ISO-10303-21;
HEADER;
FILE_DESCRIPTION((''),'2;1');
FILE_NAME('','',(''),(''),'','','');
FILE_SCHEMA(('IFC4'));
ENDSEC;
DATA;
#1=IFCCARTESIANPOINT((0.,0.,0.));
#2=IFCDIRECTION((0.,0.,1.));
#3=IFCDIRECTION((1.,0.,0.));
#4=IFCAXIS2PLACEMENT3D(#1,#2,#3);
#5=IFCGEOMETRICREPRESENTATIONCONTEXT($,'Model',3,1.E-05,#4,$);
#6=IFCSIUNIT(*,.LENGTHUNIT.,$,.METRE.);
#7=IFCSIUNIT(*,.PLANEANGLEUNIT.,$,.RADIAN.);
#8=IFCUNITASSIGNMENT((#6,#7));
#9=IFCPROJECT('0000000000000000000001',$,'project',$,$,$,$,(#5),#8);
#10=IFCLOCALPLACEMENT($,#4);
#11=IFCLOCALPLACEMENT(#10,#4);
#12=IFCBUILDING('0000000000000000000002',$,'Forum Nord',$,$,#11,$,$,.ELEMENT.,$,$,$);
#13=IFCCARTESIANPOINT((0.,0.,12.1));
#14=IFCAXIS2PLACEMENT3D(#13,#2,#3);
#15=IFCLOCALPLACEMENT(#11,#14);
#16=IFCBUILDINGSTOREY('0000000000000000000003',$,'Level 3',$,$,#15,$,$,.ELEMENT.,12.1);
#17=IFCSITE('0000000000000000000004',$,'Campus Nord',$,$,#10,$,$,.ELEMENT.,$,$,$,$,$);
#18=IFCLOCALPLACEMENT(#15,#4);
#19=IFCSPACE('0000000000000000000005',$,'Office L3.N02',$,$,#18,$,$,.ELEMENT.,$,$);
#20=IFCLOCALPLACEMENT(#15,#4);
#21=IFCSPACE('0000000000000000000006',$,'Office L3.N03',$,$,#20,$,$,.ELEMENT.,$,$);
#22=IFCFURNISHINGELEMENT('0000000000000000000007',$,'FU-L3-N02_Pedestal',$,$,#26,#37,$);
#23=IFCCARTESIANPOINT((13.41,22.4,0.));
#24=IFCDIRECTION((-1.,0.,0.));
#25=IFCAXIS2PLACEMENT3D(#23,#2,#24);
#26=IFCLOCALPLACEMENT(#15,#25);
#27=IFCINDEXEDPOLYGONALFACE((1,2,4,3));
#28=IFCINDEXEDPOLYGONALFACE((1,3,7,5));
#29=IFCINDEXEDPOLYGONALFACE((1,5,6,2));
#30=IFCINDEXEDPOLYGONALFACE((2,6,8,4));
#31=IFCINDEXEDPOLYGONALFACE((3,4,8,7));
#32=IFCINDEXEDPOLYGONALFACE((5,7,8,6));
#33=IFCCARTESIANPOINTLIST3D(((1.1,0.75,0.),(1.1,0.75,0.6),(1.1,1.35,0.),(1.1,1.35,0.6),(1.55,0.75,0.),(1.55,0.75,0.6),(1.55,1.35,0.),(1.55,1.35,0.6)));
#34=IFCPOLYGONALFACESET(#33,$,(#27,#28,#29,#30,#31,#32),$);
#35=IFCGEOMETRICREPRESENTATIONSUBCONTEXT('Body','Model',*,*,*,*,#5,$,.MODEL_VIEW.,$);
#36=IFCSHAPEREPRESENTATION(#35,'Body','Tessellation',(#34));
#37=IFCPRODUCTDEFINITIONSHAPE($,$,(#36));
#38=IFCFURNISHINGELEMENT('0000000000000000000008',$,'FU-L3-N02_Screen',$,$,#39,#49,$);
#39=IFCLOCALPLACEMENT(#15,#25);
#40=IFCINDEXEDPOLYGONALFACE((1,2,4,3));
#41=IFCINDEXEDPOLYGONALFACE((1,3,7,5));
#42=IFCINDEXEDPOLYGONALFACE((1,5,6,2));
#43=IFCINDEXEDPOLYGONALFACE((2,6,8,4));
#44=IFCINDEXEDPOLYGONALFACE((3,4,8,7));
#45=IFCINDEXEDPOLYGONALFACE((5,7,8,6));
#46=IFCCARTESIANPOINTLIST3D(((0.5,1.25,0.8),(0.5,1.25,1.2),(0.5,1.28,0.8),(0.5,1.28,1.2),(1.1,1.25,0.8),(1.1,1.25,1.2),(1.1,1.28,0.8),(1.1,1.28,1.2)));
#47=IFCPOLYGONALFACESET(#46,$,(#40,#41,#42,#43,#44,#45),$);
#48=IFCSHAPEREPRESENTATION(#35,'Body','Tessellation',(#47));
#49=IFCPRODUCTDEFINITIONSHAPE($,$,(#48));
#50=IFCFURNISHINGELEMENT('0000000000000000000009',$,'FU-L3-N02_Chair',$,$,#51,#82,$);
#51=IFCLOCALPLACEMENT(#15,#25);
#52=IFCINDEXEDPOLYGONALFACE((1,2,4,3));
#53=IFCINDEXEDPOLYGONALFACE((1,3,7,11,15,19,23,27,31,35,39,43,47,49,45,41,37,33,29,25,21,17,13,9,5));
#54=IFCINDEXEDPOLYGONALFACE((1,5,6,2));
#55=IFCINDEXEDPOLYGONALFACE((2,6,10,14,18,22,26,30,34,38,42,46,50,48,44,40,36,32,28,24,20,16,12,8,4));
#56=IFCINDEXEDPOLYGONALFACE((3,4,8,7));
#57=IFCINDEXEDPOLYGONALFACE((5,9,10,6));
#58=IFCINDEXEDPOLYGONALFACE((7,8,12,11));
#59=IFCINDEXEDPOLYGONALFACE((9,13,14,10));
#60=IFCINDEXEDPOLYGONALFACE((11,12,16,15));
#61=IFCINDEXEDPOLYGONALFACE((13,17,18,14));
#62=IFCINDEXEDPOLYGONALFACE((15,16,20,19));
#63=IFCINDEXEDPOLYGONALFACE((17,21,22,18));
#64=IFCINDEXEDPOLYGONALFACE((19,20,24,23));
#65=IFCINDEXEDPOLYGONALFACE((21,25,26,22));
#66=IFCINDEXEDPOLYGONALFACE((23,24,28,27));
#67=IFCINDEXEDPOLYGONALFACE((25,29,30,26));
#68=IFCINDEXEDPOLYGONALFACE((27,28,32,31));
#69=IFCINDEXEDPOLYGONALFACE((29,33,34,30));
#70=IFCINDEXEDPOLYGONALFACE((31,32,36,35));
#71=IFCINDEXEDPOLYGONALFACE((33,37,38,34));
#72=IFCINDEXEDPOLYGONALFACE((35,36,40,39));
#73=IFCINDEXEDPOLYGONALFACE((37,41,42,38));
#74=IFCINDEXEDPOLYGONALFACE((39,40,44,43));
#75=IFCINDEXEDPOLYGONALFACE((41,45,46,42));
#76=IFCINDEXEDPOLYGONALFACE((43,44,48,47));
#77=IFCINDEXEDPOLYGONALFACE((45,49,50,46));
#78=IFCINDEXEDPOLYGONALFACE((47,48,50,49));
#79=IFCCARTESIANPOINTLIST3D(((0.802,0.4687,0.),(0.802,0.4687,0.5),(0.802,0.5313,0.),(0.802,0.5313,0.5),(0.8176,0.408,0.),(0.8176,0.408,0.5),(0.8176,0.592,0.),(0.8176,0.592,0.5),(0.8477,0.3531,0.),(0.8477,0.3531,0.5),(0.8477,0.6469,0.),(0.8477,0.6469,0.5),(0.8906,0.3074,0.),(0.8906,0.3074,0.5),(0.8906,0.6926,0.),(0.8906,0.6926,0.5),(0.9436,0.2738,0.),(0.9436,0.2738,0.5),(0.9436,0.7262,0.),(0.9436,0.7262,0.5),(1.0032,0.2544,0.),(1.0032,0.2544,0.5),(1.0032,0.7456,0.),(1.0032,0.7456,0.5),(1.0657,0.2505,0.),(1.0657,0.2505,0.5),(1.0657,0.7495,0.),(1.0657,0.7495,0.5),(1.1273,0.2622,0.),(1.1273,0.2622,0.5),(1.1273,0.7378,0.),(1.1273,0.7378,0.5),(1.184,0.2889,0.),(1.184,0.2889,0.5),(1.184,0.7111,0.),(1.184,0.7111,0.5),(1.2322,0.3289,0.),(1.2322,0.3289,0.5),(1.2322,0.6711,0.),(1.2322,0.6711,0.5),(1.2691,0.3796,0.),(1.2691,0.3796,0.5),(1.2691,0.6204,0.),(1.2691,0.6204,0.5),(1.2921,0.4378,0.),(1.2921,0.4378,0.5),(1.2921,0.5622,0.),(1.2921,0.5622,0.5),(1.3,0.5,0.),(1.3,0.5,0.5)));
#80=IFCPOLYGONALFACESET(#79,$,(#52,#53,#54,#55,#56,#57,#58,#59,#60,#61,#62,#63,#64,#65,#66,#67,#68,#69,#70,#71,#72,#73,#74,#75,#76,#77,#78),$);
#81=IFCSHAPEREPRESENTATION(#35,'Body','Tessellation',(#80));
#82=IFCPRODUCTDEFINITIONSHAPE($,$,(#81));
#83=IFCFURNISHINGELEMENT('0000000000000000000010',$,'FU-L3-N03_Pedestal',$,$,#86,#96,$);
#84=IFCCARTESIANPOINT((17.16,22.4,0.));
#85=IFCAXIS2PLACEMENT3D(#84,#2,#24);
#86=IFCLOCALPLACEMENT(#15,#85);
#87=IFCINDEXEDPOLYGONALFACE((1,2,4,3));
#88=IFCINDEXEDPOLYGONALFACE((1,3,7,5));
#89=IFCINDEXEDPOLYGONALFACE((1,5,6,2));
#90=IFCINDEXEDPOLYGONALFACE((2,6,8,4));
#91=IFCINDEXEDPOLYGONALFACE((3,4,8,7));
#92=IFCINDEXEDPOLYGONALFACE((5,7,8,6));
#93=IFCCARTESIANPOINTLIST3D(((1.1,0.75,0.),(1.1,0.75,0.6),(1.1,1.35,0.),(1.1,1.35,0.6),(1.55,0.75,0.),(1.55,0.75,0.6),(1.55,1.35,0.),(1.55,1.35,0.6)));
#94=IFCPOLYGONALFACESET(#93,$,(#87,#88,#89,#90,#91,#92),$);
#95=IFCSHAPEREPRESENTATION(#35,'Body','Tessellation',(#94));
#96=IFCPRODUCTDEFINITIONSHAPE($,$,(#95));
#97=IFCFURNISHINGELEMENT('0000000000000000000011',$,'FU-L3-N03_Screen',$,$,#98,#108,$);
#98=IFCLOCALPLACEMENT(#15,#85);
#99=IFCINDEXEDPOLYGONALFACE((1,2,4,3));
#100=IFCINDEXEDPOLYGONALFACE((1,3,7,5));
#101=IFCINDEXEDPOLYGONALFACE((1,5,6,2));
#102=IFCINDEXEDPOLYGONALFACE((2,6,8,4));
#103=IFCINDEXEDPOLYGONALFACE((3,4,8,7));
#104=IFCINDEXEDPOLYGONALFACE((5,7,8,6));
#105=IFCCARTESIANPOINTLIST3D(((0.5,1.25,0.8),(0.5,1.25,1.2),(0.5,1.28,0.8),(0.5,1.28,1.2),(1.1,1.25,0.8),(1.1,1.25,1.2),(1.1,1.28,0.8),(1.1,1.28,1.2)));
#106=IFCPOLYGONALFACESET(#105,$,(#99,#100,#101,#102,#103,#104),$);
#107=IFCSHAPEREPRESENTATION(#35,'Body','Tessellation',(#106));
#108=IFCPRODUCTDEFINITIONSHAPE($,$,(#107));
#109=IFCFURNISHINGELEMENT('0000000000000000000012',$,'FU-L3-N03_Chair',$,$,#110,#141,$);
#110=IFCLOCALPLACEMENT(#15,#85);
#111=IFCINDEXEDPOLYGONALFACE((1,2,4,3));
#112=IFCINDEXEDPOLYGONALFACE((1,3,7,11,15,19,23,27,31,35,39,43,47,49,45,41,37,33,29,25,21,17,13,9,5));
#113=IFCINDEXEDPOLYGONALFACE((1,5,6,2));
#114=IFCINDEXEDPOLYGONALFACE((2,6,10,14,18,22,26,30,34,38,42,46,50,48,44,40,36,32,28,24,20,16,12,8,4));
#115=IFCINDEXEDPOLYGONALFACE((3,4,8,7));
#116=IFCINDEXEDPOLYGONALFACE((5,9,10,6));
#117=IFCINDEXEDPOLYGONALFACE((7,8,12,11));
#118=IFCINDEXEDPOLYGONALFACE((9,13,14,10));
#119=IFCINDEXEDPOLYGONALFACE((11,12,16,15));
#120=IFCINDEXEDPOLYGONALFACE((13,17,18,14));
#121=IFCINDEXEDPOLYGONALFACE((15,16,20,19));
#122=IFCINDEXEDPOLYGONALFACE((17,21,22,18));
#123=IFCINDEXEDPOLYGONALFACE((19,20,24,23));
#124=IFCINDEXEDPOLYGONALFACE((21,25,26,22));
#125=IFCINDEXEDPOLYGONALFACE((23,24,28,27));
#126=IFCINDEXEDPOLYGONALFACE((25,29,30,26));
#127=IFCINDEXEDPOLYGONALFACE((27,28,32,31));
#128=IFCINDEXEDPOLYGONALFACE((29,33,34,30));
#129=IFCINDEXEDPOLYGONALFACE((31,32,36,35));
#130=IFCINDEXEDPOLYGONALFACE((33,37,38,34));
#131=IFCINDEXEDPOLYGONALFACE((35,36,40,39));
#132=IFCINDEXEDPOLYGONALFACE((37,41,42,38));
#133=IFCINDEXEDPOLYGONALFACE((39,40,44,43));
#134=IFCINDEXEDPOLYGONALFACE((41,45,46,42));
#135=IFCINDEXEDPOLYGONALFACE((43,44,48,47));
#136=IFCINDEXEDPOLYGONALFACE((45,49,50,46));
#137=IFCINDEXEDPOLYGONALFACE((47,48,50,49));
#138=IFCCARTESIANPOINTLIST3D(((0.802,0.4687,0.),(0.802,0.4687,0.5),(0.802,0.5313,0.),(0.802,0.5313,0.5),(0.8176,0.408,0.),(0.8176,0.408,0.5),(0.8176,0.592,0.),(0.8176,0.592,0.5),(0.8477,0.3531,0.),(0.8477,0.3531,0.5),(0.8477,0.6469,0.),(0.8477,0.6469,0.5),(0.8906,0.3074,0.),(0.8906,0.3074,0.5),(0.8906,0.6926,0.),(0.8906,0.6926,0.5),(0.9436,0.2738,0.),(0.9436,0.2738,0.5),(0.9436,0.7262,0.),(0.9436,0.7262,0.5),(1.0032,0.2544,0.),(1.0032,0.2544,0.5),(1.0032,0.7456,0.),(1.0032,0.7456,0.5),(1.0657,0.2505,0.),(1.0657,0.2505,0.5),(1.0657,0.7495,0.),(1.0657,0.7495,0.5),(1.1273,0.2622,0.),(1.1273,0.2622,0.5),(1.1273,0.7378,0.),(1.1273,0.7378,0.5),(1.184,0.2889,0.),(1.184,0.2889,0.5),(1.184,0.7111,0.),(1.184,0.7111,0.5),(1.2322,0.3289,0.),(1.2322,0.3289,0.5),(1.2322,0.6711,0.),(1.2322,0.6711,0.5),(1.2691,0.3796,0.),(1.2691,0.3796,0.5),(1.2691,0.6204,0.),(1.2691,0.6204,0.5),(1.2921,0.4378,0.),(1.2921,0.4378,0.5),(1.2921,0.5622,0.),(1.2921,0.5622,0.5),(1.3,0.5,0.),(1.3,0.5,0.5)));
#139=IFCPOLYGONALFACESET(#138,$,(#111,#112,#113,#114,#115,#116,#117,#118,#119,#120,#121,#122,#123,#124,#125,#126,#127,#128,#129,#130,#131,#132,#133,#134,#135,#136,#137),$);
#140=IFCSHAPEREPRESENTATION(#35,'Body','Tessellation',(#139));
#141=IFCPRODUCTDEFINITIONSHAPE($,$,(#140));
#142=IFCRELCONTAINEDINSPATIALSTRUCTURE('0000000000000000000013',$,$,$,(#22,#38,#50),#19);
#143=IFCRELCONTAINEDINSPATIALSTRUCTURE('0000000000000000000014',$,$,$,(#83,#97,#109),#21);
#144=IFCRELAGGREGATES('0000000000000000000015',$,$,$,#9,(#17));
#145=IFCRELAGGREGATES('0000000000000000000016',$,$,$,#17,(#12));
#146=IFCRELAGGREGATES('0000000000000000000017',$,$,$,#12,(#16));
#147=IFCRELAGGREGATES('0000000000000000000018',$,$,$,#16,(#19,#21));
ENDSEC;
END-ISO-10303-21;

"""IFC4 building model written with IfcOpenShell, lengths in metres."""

from ifc_helpers import new_model, si_unit, frame, frame_2d, origin_with_axes, place, context, subcontext, project, spatial, rectangle, circle, extrude, element, save


model = new_model("IFC4")

# Units and contexts
model_context = context("Model", 3, precision=1e-05, world=origin_with_axes())
body_context = subcontext(model_context, "Body", "Model", "MODEL_VIEW")
ifc_project = project(units=[si_unit("LENGTHUNIT", "METRE"), si_unit("PLANEANGLEUNIT", "RADIAN")], contexts=[model_context])

# Site, building, storey
site_placement = place(None, origin_with_axes())
site = spatial("IfcSite", under=ifc_project, at=site_placement, Name="Campus Nord", CompositionType="ELEMENT")
building_placement = place(site_placement, origin_with_axes())
building = spatial("IfcBuilding", under=site, at=building_placement, Name="Forum Nord", CompositionType="ELEMENT")
storey_placement = place(building_placement, frame((0.0, 0.0, 12.1), z_axis=(0.0, 0.0, 1.0), x_axis=(1.0, 0.0, 0.0)))
storey = spatial("IfcBuildingStorey", under=building, at=storey_placement, Name="Level 3", CompositionType="ELEMENT", Elevation=12.1)

# Shared definitions
space_1_placement = place(storey_placement, origin_with_axes())
space_1 = spatial("IfcSpace", under=storey, at=space_1_placement, Name="Office L3.N02", CompositionType="ELEMENT")

# Furnishing elements
furnishing_1_placement = place(storey_placement, frame((13.41, 22.4, 0.0), z_axis=(0.0, 0.0, 1.0), x_axis=(-1.0, 0.0, 0.0)))
element("IfcFurnishingElement", 1, at=furnishing_1_placement, inside=space_1, Name="FU-L3-N02_Pedestal", context=body_context, shape_type="SweptSolid", body=[
    extrude(rectangle(XDim=0.45, YDim=0.6, at=frame_2d((1.325, 1.05), x_axis=(1.0, 0.0))), origin_with_axes(), (0.0, 0.0, 1.0), 0.6),
])
furnishing_2_placement = place(storey_placement, frame((13.41, 22.4, 0.0), z_axis=(0.0, 0.0, 1.0), x_axis=(-1.0, 0.0, 0.0)))
element("IfcFurnishingElement", 2, at=furnishing_2_placement, inside=space_1, Name="FU-L3-N02_Screen", context=body_context, shape_type="SweptSolid", body=[
    extrude(rectangle(XDim=0.6, YDim=0.03, at=frame_2d((0.8, 1.265), x_axis=(1.0, 0.0))), frame((0.0, 0.0, 0.8), z_axis=(0.0, 0.0, 1.0), x_axis=(1.0, 0.0, 0.0)), (0.0, 0.0, 1.0), 0.4),
])
furnishing_3_placement = place(storey_placement, frame((13.41, 22.4, 0.0), z_axis=(0.0, 0.0, 1.0), x_axis=(-1.0, 0.0, 0.0)))
element("IfcFurnishingElement", 3, at=furnishing_3_placement, inside=space_1, Name="FU-L3-N02_Chair", context=body_context, shape_type="SweptSolid", body=[
    extrude(circle(Radius=0.25, at=frame_2d((1.05, 0.5), x_axis=(1.0, 0.0))), origin_with_axes(), (0.0, 0.0, 1.0), 0.5),
])

# Shared definitions
space_2_placement = place(storey_placement, origin_with_axes())
space_2 = spatial("IfcSpace", under=storey, at=space_2_placement, Name="Office L3.N03", CompositionType="ELEMENT")

# Furnishing elements
furnishing_4_placement = place(storey_placement, frame((17.16, 22.4, 0.0), z_axis=(0.0, 0.0, 1.0), x_axis=(-1.0, 0.0, 0.0)))
element("IfcFurnishingElement", 4, at=furnishing_4_placement, inside=space_2, Name="FU-L3-N03_Pedestal", context=body_context, shape_type="SweptSolid", body=[
    extrude(rectangle(XDim=0.45, YDim=0.6, at=frame_2d((1.325, 1.05), x_axis=(1.0, 0.0))), origin_with_axes(), (0.0, 0.0, 1.0), 0.6),
])
furnishing_5_placement = place(storey_placement, frame((17.16, 22.4, 0.0), z_axis=(0.0, 0.0, 1.0), x_axis=(-1.0, 0.0, 0.0)))
element("IfcFurnishingElement", 5, at=furnishing_5_placement, inside=space_2, Name="FU-L3-N03_Screen", context=body_context, shape_type="SweptSolid", body=[
    extrude(rectangle(XDim=0.6, YDim=0.03, at=frame_2d((0.8, 1.265), x_axis=(1.0, 0.0))), frame((0.0, 0.0, 0.8), z_axis=(0.0, 0.0, 1.0), x_axis=(1.0, 0.0, 0.0)), (0.0, 0.0, 1.0), 0.4),
])
furnishing_6_placement = place(storey_placement, frame((17.16, 22.4, 0.0), z_axis=(0.0, 0.0, 1.0), x_axis=(-1.0, 0.0, 0.0)))
element("IfcFurnishingElement", 6, at=furnishing_6_placement, inside=space_2, Name="FU-L3-N03_Chair", context=body_context, shape_type="SweptSolid", body=[
    extrude(circle(Radius=0.25, at=frame_2d((1.05, 0.5), x_axis=(1.0, 0.0))), origin_with_axes(), (0.0, 0.0, 1.0), 0.5),
])

save(model, "model.ifc")
